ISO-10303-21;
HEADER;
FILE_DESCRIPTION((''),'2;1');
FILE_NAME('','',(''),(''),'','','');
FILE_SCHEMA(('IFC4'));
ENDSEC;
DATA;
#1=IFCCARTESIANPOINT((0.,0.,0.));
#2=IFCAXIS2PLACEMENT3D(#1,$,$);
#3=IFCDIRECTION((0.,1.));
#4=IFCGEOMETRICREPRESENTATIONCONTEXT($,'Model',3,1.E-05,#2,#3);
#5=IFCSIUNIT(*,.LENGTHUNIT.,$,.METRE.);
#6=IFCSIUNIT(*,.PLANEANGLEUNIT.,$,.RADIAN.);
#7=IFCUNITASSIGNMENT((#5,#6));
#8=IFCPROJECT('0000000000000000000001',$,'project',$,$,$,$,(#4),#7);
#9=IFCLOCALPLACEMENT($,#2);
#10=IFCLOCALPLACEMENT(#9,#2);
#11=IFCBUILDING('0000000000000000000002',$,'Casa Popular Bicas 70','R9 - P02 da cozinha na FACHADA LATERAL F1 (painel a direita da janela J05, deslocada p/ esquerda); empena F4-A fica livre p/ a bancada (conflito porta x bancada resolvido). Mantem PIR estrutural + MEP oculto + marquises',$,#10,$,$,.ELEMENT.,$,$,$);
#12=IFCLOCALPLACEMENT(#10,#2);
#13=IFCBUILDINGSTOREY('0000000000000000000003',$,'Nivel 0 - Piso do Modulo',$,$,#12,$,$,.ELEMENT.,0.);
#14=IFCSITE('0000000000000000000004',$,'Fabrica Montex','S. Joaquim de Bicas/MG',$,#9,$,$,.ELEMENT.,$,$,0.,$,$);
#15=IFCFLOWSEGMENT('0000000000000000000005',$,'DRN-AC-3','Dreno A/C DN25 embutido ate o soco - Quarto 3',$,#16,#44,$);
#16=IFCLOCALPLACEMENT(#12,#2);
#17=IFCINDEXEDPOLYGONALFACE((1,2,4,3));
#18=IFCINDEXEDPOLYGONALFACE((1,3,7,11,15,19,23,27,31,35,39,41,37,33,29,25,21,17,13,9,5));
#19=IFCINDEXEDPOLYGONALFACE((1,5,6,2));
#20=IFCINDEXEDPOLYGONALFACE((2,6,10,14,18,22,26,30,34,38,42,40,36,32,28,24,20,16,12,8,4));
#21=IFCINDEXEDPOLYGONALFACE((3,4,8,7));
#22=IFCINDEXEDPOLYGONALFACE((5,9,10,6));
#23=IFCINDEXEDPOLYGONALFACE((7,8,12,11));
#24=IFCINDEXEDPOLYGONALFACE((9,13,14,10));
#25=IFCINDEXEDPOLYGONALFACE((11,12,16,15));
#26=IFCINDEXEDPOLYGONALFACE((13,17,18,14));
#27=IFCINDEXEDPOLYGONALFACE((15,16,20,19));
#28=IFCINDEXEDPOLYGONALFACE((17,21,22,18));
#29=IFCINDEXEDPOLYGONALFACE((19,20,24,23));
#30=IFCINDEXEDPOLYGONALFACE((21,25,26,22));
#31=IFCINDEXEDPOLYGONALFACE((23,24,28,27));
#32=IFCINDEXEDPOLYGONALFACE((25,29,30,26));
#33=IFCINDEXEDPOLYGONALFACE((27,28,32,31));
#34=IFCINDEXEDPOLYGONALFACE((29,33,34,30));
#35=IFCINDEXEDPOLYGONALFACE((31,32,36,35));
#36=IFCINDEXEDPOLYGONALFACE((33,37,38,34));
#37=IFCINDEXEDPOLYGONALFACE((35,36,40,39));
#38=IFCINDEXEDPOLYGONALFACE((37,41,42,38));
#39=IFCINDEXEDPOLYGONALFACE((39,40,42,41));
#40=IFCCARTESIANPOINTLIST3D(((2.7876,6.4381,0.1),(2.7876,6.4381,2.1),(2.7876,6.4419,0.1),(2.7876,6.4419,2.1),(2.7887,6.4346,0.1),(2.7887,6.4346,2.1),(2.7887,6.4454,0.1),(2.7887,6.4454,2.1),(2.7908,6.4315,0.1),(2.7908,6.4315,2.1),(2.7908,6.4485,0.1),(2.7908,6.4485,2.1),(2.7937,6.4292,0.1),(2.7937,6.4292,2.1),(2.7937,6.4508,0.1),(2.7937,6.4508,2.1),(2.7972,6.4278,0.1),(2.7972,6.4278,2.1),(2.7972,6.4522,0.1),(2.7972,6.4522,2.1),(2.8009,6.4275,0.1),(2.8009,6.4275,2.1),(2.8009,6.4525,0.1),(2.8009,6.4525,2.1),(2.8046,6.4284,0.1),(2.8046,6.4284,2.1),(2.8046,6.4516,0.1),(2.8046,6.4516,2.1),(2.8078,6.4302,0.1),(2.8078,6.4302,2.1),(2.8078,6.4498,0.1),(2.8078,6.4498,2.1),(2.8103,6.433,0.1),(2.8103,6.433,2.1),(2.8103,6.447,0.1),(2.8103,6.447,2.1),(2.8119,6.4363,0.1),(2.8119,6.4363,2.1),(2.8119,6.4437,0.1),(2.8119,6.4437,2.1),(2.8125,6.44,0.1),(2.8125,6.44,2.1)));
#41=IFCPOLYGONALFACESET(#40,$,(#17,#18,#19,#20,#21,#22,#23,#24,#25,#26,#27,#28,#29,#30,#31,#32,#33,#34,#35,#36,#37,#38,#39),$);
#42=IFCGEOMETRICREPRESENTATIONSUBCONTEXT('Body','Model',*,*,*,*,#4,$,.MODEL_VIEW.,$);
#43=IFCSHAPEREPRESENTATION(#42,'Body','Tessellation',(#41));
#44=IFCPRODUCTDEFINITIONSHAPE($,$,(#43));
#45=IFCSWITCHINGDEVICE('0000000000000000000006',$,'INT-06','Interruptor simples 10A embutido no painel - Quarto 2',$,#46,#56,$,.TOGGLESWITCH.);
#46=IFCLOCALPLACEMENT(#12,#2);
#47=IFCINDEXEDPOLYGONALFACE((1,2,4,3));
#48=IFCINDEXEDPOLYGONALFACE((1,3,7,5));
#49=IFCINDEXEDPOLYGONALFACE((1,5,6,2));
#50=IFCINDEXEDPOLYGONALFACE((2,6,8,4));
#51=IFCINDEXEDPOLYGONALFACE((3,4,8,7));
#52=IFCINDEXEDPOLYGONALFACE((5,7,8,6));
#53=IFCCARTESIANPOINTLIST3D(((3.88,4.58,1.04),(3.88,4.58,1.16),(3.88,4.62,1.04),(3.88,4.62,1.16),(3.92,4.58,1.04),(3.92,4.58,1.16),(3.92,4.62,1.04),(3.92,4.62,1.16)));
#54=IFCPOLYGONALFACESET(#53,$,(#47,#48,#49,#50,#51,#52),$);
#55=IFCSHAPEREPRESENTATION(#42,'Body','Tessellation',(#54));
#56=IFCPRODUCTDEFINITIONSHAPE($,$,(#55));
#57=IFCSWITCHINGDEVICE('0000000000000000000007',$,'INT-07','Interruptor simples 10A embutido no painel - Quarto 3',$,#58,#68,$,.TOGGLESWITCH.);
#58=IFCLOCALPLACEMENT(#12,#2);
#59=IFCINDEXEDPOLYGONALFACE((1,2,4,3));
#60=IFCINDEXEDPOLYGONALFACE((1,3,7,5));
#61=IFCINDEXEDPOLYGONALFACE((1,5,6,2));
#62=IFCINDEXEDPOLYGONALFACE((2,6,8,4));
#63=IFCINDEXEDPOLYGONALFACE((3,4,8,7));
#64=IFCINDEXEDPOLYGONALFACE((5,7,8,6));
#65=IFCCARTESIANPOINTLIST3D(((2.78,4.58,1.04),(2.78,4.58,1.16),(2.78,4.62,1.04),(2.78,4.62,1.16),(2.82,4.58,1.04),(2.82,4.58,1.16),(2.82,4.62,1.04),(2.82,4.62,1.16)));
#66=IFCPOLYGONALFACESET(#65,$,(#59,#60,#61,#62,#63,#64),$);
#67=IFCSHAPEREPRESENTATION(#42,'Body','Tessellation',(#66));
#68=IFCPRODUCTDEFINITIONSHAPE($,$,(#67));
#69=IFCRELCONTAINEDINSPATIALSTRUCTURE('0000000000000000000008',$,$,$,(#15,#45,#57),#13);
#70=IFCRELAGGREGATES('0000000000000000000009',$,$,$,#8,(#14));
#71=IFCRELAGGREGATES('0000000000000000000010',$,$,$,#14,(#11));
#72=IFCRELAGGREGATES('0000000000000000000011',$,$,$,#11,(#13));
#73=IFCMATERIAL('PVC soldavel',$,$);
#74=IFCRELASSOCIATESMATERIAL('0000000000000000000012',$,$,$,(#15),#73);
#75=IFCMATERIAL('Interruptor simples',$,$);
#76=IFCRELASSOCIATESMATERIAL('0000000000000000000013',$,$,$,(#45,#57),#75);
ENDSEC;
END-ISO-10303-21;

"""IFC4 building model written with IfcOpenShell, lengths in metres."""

from ifc_helpers import new_model, si_unit, direction, frame, frame_2d, origin, origin_2d, place, context, subcontext, project, spatial, rectangle, circle, extrude, material, element, save


model = new_model("IFC4")

# Units and contexts
model_context = context("Model", 3, precision=1e-05, world=origin(), true_north=direction((0.0, 1.0)))
body_context = subcontext(model_context, "Body", "Model", "MODEL_VIEW")
ifc_project = project(units=[si_unit("LENGTHUNIT", "METRE"), si_unit("PLANEANGLEUNIT", "RADIAN")], contexts=[model_context])

# Site, building, storey
site_placement = place(None, origin())
site = spatial("IfcSite", under=ifc_project, at=site_placement, Name="Fabrica Montex", Description="S. Joaquim de Bicas/MG", CompositionType="ELEMENT", RefElevation=0.0)
building_placement = place(site_placement, origin())
building = spatial("IfcBuilding", under=site, at=building_placement, Name="Casa Popular Bicas 70", Description="R9 - P02 da cozinha na FACHADA LATERAL F1 (painel a direita da janela J05, deslocada p/ esquerda); empena F4-A fica livre p/ a bancada (conflito porta x bancada resolvido). Mantem PIR estrutural + MEP oculto + marquises", CompositionType="ELEMENT")
storey_placement = place(building_placement, origin())
storey = spatial("IfcBuildingStorey", under=building, at=storey_placement, Name="Nivel 0 - Piso do Modulo", CompositionType="ELEMENT", Elevation=0.0)

# Flow segment
ifc_material_1 = material(Name="PVC soldavel")
flow_segment_placement = place(storey_placement, frame((2.8, 6.44, 2.1), z_axis=(0.0, 0.0, -1.0), x_axis=(1.0, 0.0, 0.0)))
element("IfcFlowSegment", 1, at=flow_segment_placement, inside=storey, material=ifc_material_1, Name="DRN-AC-3", Description="Dreno A/C DN25 embutido ate o soco - Quarto 3", context=body_context, shape_type="SweptSolid", body=[
    extrude(circle(Radius=0.0125, at=origin_2d()), origin(), (0.0, 0.0, 1.0), 2.0),
])

# Switching devices
ifc_material_2 = material(Name="Interruptor simples")
for number, where, name, description in (
    (2, (3.88, 4.58, 1.04), "INT-06", "Interruptor simples 10A embutido no painel - Quarto 2"),
    (3, (2.78, 4.58, 1.04), "INT-07", "Interruptor simples 10A embutido no painel - Quarto 3"),
):
    element("IfcSwitchingDevice", number, at=place(storey_placement, frame(where)), inside=storey, material=ifc_material_2, Name=name, Description=description, PredefinedType="TOGGLESWITCH", context=body_context, shape_type="SweptSolid", body=[
        extrude(rectangle(XDim=0.04, YDim=0.04, at=frame_2d((0.02, 0.02))), origin(), (0.0, 0.0, 1.0), 0.12),
    ])

save(model, "model.ifc")
